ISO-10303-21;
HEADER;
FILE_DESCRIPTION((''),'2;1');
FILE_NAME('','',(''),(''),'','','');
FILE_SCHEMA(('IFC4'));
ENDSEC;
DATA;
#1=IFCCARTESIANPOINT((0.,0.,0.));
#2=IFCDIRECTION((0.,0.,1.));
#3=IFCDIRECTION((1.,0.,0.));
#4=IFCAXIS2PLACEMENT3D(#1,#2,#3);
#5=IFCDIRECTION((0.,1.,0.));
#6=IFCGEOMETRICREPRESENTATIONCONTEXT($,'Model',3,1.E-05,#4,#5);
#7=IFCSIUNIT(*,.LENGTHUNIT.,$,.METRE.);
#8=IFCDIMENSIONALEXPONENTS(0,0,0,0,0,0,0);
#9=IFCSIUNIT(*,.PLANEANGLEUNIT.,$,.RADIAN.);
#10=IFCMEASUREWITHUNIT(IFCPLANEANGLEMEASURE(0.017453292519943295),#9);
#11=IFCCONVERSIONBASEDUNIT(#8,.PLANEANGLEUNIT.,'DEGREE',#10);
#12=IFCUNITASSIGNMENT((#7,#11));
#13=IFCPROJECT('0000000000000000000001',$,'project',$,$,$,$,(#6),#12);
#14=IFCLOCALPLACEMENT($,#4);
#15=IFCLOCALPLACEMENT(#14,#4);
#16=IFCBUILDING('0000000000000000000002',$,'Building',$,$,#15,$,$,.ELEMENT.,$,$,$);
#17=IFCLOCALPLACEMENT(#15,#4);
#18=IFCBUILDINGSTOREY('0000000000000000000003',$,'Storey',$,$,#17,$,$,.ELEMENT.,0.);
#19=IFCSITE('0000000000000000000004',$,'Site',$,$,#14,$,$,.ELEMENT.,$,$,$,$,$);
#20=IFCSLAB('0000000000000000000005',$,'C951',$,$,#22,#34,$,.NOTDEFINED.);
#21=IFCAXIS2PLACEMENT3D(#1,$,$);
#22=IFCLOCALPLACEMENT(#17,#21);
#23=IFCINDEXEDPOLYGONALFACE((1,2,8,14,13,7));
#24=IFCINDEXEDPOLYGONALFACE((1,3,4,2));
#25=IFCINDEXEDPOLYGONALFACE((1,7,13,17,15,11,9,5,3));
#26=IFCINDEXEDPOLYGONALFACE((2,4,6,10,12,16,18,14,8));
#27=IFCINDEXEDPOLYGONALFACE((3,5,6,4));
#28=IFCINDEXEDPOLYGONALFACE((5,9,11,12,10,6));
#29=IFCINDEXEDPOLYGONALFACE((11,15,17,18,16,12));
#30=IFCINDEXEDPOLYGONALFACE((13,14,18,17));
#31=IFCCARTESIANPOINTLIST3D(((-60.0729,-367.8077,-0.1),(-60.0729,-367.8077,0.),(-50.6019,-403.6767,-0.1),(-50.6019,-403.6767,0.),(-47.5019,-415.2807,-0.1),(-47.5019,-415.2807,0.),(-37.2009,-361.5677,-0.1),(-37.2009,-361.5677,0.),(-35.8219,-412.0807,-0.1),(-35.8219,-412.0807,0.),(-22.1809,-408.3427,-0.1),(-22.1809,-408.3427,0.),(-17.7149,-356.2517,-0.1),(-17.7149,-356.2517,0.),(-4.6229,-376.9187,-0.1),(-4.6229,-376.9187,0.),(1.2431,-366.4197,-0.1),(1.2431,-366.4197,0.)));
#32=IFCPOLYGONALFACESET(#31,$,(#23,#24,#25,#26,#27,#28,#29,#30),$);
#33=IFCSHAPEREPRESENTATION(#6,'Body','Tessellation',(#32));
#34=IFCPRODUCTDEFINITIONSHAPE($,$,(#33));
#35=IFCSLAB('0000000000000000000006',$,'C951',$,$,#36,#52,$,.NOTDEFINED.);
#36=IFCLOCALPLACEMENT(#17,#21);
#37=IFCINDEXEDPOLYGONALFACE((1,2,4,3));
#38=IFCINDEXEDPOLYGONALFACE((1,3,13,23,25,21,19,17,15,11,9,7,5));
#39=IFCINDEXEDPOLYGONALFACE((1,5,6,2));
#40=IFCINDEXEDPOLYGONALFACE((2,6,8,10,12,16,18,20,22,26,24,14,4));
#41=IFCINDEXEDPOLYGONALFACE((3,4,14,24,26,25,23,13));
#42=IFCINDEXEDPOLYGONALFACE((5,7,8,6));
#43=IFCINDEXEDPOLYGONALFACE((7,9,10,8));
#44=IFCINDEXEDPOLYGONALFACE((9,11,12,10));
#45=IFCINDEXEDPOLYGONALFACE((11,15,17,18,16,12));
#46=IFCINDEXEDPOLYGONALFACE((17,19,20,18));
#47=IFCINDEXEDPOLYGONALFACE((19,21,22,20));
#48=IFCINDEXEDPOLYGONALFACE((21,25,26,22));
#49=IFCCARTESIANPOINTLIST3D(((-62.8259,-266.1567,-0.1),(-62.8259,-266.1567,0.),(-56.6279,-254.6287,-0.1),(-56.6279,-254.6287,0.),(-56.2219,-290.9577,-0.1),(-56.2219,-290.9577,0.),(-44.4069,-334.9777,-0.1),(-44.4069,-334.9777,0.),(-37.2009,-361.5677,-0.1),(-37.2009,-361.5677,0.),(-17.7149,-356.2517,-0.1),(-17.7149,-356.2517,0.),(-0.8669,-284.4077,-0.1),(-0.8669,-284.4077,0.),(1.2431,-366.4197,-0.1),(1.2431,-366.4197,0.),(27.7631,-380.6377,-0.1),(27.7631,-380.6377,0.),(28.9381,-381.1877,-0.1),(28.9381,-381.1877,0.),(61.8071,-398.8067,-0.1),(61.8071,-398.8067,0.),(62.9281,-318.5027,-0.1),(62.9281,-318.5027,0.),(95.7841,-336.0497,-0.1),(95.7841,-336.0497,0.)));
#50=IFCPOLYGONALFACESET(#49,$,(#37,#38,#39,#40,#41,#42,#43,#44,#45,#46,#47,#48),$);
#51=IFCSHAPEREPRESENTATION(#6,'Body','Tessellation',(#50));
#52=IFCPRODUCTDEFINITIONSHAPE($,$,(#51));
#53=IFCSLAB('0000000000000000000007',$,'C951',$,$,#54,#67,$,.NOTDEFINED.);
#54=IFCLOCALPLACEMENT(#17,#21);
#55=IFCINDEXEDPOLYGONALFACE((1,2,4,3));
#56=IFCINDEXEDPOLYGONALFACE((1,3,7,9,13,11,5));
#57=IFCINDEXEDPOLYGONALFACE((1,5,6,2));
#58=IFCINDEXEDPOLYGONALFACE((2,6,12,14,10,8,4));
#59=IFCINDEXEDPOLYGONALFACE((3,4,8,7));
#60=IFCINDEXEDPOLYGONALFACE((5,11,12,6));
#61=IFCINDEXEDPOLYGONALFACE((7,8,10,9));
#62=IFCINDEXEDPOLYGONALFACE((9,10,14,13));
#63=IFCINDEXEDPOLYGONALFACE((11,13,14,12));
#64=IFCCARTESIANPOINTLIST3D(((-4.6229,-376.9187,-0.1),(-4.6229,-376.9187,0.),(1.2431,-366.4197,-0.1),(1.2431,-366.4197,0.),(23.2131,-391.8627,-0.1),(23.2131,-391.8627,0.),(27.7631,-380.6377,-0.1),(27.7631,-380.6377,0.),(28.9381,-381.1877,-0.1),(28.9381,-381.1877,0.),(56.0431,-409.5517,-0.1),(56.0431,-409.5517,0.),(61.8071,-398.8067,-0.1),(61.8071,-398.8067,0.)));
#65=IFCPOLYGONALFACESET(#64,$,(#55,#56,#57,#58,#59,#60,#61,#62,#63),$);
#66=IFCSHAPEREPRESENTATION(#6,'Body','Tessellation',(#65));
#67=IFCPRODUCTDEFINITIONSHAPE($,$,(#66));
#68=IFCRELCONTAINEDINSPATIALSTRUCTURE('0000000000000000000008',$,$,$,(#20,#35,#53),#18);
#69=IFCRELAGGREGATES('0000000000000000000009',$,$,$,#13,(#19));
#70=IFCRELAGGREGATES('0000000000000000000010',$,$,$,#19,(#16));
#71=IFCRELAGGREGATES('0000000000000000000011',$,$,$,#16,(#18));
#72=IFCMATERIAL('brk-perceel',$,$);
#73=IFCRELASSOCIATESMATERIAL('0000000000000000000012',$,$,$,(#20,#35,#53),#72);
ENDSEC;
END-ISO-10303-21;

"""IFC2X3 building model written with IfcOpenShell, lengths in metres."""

from ifc_helpers import new_model, entity, si_unit, converted_unit, direction, frame, origin_with_axes, place, context, project, spatial, polyline, outline, extrude, material, element, save


model = new_model("IFC2X3")

# Units and contexts
model_context = context("Model", 3, precision=1e-05, world=origin_with_axes(), true_north=direction((0.0, 1.0, 0.0)))
ifc_project = project(units=[si_unit("LENGTHUNIT", "METRE"), converted_unit("PLANEANGLEUNIT", "DEGREE", entity("IfcPlaneAngleMeasure", 0.017453292519943295), si_unit("PLANEANGLEUNIT", "RADIAN"), dimensions=[0, 0, 0, 0, 0, 0, 0])], contexts=[model_context])

# Site, building, storey
site_placement = place(None, origin_with_axes())
site = spatial("IfcSite", under=ifc_project, at=site_placement, Name="Site", CompositionType="ELEMENT")
building_placement = place(site_placement, origin_with_axes())
building = spatial("IfcBuilding", under=site, at=building_placement, Name="Building", CompositionType="ELEMENT")
storey_placement = place(building_placement, origin_with_axes())
storey = spatial("IfcBuildingStorey", under=building, at=storey_placement, Name="Storey", CompositionType="ELEMENT", Elevation=0.0)

# Slabs
ifc_material = material(Name="brk-perceel")
slab_1_placement = place(storey_placement, frame((0.0, 0.0, -0.1), z_axis=(0.0, 0.0, 1.0), x_axis=(1.0, 0.0, 0.0)))
element("IfcSlab", 1, at=slab_1_placement, inside=storey, material=ifc_material, Name="C951", PredefinedType="NOTDEFINED", context=model_context, shape_type="SweptSolid", body=[
    extrude(outline(polyline([(-50.6019, -403.6767), (-60.0729, -367.8077), (-37.2009, -361.5677), (-17.7149, -356.2517), (1.2431, -366.4197), (-4.6229, -376.9187), (-22.1809, -408.3427), (-35.8219, -412.0807), (-47.5019, -415.2807), (-50.6019, -403.6767)])), origin_with_axes(), (0.0, 0.0, 1.0), 0.1),
])
slab_2_placement = place(storey_placement, frame((0.0, 0.0, -0.1), z_axis=(0.0, 0.0, 1.0), x_axis=(1.0, 0.0, 0.0)))
element("IfcSlab", 2, at=slab_2_placement, inside=storey, material=ifc_material, Name="C951", PredefinedType="NOTDEFINED", context=model_context, shape_type="SweptSolid", body=[
    extrude(outline(polyline([(28.9381, -381.1877), (27.7631, -380.6377), (1.2431, -366.4197), (-17.7149, -356.2517), (-37.2009, -361.5677), (-44.4069, -334.9777), (-56.2219, -290.9577), (-62.8259, -266.1567), (-56.6279, -254.6287), (-0.8669, -284.4077), (62.9281, -318.5027), (95.7841, -336.0497), (61.8071, -398.8067), (28.9381, -381.1877)])), origin_with_axes(), (0.0, 0.0, 1.0), 0.1),
])
slab_3_placement = place(storey_placement, frame((0.0, 0.0, -0.1), z_axis=(0.0, 0.0, 1.0), x_axis=(1.0, 0.0, 0.0)))
element("IfcSlab", 3, at=slab_3_placement, inside=storey, material=ifc_material, Name="C951", PredefinedType="NOTDEFINED", context=model_context, shape_type="SweptSolid", body=[
    extrude(outline(polyline([(23.2131, -391.8627), (-4.6229, -376.9187), (1.2431, -366.4197), (27.7631, -380.6377), (28.9381, -381.1877), (61.8071, -398.8067), (56.0431, -409.5517), (23.2131, -391.8627)])), origin_with_axes(), (0.0, 0.0, 1.0), 0.1),
])

save(model, "model.ifc")
